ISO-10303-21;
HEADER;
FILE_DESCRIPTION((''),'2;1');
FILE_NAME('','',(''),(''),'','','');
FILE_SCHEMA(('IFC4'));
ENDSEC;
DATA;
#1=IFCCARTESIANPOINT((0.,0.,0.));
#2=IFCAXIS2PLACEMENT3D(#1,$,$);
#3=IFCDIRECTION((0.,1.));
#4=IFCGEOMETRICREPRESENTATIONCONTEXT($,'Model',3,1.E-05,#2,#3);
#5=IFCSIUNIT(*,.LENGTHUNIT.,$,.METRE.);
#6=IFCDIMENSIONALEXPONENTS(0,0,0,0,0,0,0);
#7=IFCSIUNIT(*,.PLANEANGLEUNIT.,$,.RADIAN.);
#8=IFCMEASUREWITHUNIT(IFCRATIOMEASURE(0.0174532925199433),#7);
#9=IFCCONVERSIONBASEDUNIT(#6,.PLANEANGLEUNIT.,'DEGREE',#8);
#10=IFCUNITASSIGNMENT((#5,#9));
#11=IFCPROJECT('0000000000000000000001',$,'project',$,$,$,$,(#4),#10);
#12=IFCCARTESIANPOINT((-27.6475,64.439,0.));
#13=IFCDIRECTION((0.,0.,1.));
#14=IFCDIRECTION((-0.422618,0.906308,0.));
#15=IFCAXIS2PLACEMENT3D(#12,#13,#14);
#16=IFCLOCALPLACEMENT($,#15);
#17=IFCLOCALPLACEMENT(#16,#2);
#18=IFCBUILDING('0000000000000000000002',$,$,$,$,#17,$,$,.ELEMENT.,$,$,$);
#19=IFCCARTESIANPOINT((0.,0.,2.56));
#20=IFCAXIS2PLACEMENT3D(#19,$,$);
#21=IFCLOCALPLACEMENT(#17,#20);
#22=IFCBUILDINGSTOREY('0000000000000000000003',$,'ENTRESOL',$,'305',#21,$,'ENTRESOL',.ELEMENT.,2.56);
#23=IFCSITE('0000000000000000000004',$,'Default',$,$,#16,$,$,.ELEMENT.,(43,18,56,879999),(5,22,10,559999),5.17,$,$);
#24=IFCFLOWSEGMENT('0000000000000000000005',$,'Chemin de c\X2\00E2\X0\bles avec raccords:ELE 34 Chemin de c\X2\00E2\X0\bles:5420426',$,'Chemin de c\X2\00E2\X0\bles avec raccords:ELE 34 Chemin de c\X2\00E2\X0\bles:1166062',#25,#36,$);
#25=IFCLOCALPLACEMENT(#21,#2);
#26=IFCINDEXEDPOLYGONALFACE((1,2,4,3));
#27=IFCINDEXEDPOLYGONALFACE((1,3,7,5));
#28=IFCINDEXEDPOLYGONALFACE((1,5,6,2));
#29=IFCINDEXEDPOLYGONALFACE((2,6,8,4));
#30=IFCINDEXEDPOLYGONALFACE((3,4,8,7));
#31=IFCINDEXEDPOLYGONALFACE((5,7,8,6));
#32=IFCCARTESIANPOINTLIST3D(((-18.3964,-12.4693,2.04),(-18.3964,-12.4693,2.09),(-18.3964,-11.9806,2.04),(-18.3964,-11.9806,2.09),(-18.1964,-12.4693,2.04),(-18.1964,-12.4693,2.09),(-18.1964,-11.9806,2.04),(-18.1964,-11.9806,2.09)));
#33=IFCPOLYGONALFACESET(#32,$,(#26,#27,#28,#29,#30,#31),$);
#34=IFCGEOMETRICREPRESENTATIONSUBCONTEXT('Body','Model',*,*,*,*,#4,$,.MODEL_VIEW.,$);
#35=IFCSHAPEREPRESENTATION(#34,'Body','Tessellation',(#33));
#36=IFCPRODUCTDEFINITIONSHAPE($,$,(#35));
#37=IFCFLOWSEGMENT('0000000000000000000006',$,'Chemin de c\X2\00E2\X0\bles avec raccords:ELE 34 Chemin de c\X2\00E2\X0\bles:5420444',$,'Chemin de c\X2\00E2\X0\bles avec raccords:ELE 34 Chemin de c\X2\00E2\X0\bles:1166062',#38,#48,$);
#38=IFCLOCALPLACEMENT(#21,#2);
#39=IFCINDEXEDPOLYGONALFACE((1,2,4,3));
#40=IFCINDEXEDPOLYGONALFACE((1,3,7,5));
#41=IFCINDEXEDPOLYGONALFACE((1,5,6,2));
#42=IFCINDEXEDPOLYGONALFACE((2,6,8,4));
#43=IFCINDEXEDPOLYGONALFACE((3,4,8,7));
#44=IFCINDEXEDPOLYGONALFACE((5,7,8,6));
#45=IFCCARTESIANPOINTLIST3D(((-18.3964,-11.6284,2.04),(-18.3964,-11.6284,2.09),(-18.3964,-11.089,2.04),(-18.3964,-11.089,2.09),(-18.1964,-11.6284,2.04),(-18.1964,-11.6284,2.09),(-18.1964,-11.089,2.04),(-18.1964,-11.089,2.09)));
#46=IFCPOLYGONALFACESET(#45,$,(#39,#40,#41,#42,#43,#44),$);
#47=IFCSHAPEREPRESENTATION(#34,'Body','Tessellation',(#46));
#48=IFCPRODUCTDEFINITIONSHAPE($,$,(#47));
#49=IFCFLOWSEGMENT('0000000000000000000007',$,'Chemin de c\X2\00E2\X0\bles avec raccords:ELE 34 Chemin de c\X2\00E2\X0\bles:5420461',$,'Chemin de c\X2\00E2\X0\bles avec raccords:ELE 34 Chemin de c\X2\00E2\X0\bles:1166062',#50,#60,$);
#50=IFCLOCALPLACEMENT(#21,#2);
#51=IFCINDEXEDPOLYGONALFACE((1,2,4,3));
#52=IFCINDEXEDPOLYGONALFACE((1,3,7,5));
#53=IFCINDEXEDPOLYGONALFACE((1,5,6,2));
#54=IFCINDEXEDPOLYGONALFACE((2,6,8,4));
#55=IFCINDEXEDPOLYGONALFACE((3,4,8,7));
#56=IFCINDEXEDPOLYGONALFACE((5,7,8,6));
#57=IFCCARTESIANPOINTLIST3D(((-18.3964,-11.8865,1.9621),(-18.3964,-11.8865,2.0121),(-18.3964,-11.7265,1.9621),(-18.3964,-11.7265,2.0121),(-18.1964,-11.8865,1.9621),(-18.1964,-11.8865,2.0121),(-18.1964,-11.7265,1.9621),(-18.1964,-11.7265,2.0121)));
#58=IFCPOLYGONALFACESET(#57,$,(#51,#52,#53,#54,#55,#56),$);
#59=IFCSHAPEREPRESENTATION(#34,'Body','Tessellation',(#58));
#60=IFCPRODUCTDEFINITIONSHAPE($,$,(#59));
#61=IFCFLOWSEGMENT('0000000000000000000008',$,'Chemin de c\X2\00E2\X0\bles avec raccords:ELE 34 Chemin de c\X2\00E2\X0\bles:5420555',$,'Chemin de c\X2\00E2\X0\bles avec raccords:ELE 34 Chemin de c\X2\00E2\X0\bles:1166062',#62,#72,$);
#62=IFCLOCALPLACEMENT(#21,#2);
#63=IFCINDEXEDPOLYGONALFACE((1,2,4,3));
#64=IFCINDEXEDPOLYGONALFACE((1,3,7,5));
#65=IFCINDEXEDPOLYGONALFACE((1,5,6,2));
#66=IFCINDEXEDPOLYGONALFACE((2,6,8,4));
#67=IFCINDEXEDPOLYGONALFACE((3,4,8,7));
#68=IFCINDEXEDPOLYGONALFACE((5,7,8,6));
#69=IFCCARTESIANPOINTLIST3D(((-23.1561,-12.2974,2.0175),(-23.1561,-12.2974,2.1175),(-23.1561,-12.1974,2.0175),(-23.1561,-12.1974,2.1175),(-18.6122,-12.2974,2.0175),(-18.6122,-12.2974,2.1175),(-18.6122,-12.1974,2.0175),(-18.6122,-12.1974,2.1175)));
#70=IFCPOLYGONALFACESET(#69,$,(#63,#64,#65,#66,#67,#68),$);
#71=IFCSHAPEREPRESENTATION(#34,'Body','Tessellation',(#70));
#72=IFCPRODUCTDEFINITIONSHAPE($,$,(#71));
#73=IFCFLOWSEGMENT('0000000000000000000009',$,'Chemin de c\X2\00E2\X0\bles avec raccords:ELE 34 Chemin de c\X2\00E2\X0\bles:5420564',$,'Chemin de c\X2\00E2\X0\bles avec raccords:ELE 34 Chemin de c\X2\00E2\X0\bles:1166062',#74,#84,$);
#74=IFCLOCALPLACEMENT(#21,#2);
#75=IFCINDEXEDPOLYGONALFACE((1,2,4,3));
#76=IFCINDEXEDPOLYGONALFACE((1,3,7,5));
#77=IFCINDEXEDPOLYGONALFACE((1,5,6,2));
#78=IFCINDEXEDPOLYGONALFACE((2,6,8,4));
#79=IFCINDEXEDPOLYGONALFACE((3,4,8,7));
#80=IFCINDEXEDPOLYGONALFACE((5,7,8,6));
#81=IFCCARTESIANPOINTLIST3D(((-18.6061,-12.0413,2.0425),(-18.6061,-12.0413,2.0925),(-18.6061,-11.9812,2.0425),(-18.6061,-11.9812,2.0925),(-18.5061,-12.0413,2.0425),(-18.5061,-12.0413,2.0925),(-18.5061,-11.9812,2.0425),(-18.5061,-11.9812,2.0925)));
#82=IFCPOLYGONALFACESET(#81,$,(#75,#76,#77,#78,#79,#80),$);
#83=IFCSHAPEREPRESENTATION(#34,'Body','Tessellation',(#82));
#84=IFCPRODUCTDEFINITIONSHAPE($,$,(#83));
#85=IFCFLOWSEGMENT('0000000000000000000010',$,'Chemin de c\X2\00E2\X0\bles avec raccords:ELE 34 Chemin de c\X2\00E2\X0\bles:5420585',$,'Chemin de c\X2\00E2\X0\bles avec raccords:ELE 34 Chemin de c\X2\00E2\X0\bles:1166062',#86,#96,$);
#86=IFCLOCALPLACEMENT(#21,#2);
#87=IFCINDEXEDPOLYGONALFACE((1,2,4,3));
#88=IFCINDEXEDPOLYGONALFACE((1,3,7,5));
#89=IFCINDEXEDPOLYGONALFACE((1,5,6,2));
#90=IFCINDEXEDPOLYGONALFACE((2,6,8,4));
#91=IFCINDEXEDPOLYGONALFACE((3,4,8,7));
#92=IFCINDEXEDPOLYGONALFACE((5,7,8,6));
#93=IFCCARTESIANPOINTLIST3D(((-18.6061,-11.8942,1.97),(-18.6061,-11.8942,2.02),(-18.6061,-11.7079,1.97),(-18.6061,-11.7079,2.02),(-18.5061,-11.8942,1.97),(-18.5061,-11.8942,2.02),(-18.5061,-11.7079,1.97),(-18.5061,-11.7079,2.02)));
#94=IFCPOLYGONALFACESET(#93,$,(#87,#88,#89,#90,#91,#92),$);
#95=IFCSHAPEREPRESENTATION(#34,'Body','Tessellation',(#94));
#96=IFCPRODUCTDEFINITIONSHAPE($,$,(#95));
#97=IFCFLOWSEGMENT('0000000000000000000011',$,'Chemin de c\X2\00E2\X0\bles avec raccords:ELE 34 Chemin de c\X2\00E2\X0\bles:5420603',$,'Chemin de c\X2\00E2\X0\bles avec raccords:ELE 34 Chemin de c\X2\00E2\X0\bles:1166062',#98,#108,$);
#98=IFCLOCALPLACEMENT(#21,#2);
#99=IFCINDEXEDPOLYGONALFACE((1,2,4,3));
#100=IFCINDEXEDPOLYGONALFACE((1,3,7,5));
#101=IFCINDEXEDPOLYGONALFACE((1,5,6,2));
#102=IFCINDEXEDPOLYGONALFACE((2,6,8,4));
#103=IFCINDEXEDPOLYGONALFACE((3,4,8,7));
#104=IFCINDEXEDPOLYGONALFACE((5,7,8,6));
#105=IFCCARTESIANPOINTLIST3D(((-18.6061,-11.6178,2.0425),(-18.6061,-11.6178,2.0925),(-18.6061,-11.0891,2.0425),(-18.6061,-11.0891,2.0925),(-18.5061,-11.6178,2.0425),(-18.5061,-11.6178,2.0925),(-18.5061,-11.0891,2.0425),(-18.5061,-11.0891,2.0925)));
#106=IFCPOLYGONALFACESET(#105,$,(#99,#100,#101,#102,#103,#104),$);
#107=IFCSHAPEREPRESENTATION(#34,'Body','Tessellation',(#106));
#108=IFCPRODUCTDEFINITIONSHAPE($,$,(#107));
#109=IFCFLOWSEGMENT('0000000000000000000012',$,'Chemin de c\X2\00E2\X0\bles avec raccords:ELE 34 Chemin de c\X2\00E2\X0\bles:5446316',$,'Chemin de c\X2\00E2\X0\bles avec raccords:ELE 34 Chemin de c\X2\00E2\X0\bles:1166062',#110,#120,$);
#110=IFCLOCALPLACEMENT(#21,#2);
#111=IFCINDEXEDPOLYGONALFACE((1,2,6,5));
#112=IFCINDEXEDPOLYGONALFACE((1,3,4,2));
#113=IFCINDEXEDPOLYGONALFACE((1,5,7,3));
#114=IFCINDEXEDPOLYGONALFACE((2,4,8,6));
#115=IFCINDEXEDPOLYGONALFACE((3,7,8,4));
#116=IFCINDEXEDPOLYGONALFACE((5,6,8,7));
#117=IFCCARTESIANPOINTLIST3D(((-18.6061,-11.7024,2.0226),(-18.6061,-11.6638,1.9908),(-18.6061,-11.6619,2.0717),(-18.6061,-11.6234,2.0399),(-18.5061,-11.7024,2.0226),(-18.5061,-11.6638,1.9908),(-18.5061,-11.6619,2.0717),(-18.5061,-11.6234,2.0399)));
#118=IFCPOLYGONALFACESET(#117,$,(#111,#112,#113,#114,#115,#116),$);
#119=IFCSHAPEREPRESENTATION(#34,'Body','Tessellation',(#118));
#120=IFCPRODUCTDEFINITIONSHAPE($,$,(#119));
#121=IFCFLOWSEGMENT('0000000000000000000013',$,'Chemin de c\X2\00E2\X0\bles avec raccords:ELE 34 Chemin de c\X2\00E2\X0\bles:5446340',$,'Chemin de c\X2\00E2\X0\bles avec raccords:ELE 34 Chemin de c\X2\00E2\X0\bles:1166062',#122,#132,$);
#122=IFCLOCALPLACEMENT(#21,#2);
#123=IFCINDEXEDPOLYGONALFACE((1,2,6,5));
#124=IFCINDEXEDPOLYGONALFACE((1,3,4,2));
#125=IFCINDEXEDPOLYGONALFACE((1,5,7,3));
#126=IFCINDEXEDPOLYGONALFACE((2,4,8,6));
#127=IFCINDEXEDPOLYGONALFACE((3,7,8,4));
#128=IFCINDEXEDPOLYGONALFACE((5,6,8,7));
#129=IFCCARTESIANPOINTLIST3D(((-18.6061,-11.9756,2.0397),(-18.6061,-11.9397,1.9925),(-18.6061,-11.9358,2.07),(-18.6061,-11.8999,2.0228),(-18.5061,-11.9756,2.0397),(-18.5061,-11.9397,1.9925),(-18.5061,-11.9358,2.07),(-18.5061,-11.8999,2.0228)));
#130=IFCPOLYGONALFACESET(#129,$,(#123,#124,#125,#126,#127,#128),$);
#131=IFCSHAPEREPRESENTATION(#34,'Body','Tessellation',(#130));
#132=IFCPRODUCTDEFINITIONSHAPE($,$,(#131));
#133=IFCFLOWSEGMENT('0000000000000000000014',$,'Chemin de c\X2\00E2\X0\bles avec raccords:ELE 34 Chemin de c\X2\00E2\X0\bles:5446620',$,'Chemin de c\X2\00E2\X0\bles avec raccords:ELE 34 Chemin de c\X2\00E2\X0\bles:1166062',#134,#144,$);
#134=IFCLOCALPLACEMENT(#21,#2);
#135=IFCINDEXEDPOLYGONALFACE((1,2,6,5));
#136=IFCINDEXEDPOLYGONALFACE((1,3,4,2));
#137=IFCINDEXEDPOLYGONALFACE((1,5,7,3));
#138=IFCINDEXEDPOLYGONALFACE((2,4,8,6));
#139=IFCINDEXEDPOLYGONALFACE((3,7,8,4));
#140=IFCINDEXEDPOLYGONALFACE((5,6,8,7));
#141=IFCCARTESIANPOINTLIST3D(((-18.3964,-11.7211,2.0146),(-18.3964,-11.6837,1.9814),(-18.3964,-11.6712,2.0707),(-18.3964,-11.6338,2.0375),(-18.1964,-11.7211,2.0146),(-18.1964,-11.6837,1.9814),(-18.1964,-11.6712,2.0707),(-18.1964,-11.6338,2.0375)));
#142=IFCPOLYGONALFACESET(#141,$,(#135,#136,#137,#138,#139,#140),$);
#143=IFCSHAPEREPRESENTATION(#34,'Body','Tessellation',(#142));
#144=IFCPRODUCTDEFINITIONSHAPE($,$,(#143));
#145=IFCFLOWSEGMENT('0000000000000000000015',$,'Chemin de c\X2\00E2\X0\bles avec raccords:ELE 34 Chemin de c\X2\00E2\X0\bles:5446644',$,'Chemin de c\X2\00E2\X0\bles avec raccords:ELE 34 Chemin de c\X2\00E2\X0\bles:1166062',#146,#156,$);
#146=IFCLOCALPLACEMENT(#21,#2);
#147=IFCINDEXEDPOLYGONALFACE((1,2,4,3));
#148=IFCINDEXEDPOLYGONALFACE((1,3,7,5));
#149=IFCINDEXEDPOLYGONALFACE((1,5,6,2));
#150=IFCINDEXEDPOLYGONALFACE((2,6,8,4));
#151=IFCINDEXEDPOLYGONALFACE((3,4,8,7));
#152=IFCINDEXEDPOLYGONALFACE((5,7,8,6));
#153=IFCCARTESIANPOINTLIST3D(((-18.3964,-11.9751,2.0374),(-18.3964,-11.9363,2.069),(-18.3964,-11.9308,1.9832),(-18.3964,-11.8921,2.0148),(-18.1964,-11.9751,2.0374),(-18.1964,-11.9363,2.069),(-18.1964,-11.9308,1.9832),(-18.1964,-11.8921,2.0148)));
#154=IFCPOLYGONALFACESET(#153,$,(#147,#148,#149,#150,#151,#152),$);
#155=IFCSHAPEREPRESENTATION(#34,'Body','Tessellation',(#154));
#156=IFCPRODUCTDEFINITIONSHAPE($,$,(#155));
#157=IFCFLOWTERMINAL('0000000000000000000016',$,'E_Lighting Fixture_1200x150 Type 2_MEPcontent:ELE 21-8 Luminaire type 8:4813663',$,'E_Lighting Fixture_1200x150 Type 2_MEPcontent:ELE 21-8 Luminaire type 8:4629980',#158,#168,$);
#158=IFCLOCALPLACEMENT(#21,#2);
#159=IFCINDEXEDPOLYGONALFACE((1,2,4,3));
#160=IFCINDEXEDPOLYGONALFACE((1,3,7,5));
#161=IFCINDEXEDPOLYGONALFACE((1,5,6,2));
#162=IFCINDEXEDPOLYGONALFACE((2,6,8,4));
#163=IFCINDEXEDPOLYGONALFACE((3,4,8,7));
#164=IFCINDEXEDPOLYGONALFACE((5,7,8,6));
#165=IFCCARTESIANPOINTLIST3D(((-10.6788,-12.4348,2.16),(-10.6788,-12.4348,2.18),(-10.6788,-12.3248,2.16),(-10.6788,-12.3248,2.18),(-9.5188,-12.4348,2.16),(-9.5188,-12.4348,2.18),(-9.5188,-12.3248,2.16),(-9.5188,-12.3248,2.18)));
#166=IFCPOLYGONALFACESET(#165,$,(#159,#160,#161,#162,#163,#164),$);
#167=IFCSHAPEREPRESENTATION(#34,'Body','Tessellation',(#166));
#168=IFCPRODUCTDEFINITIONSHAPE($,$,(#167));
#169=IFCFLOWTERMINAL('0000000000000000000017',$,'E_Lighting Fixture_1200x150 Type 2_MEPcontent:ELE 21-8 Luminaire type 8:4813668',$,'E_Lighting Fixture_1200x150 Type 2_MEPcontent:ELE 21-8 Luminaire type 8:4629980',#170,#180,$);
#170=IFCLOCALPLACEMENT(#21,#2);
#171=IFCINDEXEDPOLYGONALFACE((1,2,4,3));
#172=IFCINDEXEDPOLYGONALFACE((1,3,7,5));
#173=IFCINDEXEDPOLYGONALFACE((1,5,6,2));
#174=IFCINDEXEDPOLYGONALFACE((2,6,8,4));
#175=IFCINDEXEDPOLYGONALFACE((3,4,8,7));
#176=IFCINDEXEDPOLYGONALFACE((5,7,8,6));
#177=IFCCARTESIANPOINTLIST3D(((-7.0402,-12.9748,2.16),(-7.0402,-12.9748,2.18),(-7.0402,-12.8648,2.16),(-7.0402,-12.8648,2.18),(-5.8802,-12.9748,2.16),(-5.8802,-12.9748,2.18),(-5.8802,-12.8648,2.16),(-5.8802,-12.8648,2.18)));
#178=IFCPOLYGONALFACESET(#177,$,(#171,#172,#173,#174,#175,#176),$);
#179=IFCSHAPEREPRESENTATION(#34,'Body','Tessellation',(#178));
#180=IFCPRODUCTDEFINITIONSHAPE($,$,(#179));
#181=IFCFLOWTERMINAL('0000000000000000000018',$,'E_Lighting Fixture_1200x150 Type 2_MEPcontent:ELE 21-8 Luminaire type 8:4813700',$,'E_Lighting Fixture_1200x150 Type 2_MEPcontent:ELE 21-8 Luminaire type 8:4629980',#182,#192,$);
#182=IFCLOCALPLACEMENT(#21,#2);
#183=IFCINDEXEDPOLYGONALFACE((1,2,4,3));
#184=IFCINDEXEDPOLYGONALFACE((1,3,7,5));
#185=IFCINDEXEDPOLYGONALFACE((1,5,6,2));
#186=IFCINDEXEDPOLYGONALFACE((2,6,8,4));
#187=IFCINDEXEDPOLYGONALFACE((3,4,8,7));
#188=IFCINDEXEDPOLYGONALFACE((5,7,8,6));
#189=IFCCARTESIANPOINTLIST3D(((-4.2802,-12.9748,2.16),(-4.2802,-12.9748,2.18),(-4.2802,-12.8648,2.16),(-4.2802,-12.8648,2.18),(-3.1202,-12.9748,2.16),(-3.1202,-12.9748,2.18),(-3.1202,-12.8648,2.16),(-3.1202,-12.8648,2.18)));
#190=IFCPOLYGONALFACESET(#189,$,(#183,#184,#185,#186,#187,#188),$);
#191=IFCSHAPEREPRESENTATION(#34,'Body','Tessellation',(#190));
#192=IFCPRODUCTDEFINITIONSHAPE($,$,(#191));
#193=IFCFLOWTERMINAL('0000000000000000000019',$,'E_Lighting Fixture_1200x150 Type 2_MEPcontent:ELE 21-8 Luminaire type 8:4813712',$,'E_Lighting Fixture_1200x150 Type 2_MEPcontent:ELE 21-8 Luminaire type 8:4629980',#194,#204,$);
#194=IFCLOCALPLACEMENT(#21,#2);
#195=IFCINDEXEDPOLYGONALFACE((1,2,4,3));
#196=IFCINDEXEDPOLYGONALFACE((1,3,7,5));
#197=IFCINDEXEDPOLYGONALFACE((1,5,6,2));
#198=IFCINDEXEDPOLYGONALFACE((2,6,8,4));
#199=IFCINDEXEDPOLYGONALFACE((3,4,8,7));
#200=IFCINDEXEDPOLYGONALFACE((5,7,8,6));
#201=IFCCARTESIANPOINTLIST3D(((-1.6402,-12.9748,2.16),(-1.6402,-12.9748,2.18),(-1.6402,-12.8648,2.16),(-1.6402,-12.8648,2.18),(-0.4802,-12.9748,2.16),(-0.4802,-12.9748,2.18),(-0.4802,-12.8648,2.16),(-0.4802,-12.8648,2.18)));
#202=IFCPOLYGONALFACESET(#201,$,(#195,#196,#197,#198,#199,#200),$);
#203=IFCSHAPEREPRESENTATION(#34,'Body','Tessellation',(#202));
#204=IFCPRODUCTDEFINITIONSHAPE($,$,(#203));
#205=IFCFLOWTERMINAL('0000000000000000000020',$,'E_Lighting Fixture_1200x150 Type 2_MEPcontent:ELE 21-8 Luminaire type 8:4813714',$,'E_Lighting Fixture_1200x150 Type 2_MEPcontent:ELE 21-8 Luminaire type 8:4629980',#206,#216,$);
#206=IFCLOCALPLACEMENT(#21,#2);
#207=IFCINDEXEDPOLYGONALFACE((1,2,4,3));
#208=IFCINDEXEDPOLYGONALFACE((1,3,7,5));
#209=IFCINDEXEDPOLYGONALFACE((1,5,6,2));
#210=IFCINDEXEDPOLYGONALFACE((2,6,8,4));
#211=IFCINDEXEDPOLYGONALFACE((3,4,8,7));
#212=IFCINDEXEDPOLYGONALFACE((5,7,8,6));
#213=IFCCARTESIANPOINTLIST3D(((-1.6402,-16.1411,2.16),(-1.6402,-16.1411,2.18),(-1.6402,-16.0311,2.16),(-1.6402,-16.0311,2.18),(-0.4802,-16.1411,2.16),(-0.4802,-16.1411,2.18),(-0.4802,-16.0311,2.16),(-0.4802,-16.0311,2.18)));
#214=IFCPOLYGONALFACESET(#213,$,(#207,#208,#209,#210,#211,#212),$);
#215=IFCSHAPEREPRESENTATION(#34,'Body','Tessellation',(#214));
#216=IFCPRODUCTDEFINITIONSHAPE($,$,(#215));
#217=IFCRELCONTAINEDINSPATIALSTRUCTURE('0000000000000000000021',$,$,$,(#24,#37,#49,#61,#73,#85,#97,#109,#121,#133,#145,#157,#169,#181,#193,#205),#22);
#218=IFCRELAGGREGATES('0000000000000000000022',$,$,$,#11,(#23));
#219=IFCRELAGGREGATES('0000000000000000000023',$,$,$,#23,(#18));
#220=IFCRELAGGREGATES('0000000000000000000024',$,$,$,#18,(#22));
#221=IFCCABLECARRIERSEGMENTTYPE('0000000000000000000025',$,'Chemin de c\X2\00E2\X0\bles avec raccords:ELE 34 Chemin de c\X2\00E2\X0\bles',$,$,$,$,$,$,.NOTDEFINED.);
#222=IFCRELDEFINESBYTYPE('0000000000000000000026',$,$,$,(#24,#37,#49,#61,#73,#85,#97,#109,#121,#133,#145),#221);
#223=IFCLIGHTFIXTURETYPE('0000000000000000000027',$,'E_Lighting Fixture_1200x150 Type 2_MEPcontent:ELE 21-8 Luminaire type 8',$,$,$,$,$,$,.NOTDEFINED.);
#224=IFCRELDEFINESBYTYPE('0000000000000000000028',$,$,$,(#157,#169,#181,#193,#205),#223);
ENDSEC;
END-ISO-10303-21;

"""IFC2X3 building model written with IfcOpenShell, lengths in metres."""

from ifc_helpers import new_model, entity, si_unit, converted_unit, direction, frame, frame_2d, origin, origin_2d_with_axis, place, context, subcontext, project, spatial, rectangle, extrude, source, transform, mapped, type_object, type_shapes, element, save


model = new_model("IFC2X3")

# Units and contexts
model_context = context("Model", 3, precision=1e-05, world=origin(), true_north=direction((0.0, 1.0)))
body_context = subcontext(model_context, "Body", "Model", "MODEL_VIEW")
ifc_project = project(units=[si_unit("LENGTHUNIT", "METRE"), converted_unit("PLANEANGLEUNIT", "DEGREE", entity("IfcRatioMeasure", 0.0174532925199433), si_unit("PLANEANGLEUNIT", "RADIAN"), dimensions=[0, 0, 0, 0, 0, 0, 0])], contexts=[model_context])

# Site, building, storey
site_placement = place(None, frame((-27.6475, 64.439, 0.0), z_axis=(0.0, 0.0, 1.0), x_axis=(-0.422618, 0.906308, 0.0)))
site = spatial("IfcSite", under=ifc_project, at=site_placement, Name="Default", CompositionType="ELEMENT", RefLatitude=(43, 18, 56, 879999), RefLongitude=(5, 22, 10, 559999), RefElevation=5.17)
building_placement = place(site_placement, origin())
building = spatial("IfcBuilding", under=site, at=building_placement, CompositionType="ELEMENT")
storey_placement = place(building_placement, frame((0.0, 0.0, 2.56)))
storey = spatial("IfcBuildingStorey", under=building, at=storey_placement, Name="ENTRESOL", ObjectType="305", LongName="ENTRESOL", CompositionType="ELEMENT", Elevation=2.56)

# Flow segments
cable_carrier_segment_type = type_object("IfcCableCarrierSegmentType", Name="Chemin de câbles avec raccords:ELE 34 Chemin de câbles", PredefinedType="NOTDEFINED")
flow_segment_1_placement = place(storey_placement, origin())
element("IfcFlowSegment", 1, at=flow_segment_1_placement, inside=storey, type_object=cable_carrier_segment_type, Name="Chemin de câbles avec raccords:ELE 34 Chemin de câbles:5420426", ObjectType="Chemin de câbles avec raccords:ELE 34 Chemin de câbles:1166062", context=body_context, shape_type="SweptSolid", body=[
    extrude(rectangle(XDim=0.4886, YDim=0.2, at=frame_2d((0.0, 0.0), x_axis=(1.0, 0.0))), frame((-18.2964, -12.2249, 2.04), z_axis=(0.0, 0.000017, 1.0), x_axis=(0.0, 1.0, -0.000017)), (0.0, 0.0, 1.0), 0.05),
])
flow_segment_2_placement = place(storey_placement, origin())
element("IfcFlowSegment", 2, at=flow_segment_2_placement, inside=storey, type_object=cable_carrier_segment_type, Name="Chemin de câbles avec raccords:ELE 34 Chemin de câbles:5420444", ObjectType="Chemin de câbles avec raccords:ELE 34 Chemin de câbles:1166062", context=body_context, shape_type="SweptSolid", body=[
    extrude(rectangle(XDim=0.5394, YDim=0.2, at=frame_2d((0.0, 0.0), x_axis=(1.0, 0.0))), frame((-18.2964, -11.3587, 2.04), z_axis=(0.0, 0.0, 1.0), x_axis=(0.0, 1.0, 0.0)), (0.0, 0.0, 1.0), 0.05),
])
flow_segment_3_placement = place(storey_placement, origin())
element("IfcFlowSegment", 3, at=flow_segment_3_placement, inside=storey, type_object=cable_carrier_segment_type, Name="Chemin de câbles avec raccords:ELE 34 Chemin de câbles:5420461", ObjectType="Chemin de câbles avec raccords:ELE 34 Chemin de câbles:1166062", context=body_context, shape_type="SweptSolid", body=[
    extrude(rectangle(XDim=0.16, YDim=0.2, at=frame_2d((0.0, 0.0), x_axis=(1.0, 0.0))), frame((-18.2964, -11.8065, 1.9621), z_axis=(0.0, 0.0, 1.0), x_axis=(0.0, 1.0, 0.0)), (0.0, 0.0, 1.0), 0.05),
])
flow_segment_4_placement = place(storey_placement, origin())
element("IfcFlowSegment", 4, at=flow_segment_4_placement, inside=storey, type_object=cable_carrier_segment_type, Name="Chemin de câbles avec raccords:ELE 34 Chemin de câbles:5420555", ObjectType="Chemin de câbles avec raccords:ELE 34 Chemin de câbles:1166062", context=body_context, shape_type="SweptSolid", body=[
    extrude(rectangle(XDim=4.5439, YDim=0.1, at=frame_2d((0.0, 0.0), x_axis=(1.0, 0.0))), frame((-20.8842, -12.2474, 2.0175)), (0.0, 0.0, 1.0), 0.1),
])
flow_segment_5_placement = place(storey_placement, origin())
element("IfcFlowSegment", 5, at=flow_segment_5_placement, inside=storey, type_object=cable_carrier_segment_type, Name="Chemin de câbles avec raccords:ELE 34 Chemin de câbles:5420564", ObjectType="Chemin de câbles avec raccords:ELE 34 Chemin de câbles:1166062", context=body_context, shape_type="SweptSolid", body=[
    extrude(rectangle(XDim=0.0601, YDim=0.1, at=frame_2d((0.0, 0.0), x_axis=(1.0, 0.0))), frame((-18.5561, -12.0113, 2.0425), z_axis=(0.0, 0.0, 1.0), x_axis=(0.0, 1.0, 0.0)), (0.0, 0.0, 1.0), 0.05),
])
flow_segment_6_placement = place(storey_placement, origin())
element("IfcFlowSegment", 6, at=flow_segment_6_placement, inside=storey, type_object=cable_carrier_segment_type, Name="Chemin de câbles avec raccords:ELE 34 Chemin de câbles:5420585", ObjectType="Chemin de câbles avec raccords:ELE 34 Chemin de câbles:1166062", context=body_context, shape_type="SweptSolid", body=[
    extrude(rectangle(XDim=0.1863, YDim=0.1, at=origin_2d_with_axis()), frame((-18.5561, -11.8011, 1.97), z_axis=(0.0, 0.0, 1.0), x_axis=(0.0, 1.0, 0.0)), (0.0, 0.0, 1.0), 0.05),
])
flow_segment_7_placement = place(storey_placement, origin())
element("IfcFlowSegment", 7, at=flow_segment_7_placement, inside=storey, type_object=cable_carrier_segment_type, Name="Chemin de câbles avec raccords:ELE 34 Chemin de câbles:5420603", ObjectType="Chemin de câbles avec raccords:ELE 34 Chemin de câbles:1166062", context=body_context, shape_type="SweptSolid", body=[
    extrude(rectangle(XDim=0.5287, YDim=0.1, at=frame_2d((0.0, 0.0), x_axis=(1.0, 0.0))), frame((-18.5561, -11.3534, 2.0425), z_axis=(0.0, 0.0, 1.0), x_axis=(0.0, -1.0, 0.0)), (0.0, 0.0, 1.0), 0.05),
])
flow_segment_8_placement = place(storey_placement, origin())
element("IfcFlowSegment", 8, at=flow_segment_8_placement, inside=storey, type_object=cable_carrier_segment_type, Name="Chemin de câbles avec raccords:ELE 34 Chemin de câbles:5446316", ObjectType="Chemin de câbles avec raccords:ELE 34 Chemin de câbles:1166062", context=body_context, shape_type="SweptSolid", body=[
    extrude(rectangle(XDim=0.0636, YDim=0.05, at=frame_2d((0.0, 0.0), x_axis=(1.0, 0.0))), frame((-18.6061, -11.6629, 2.0312), z_axis=(1.0, 0.0, 0.0), x_axis=(0.0, 0.636095, 0.771611)), (0.0, 0.0, 1.0), 0.1),
])
flow_segment_9_placement = place(storey_placement, origin())
element("IfcFlowSegment", 9, at=flow_segment_9_placement, inside=storey, type_object=cable_carrier_segment_type, Name="Chemin de câbles avec raccords:ELE 34 Chemin de câbles:5446340", ObjectType="Chemin de câbles avec raccords:ELE 34 Chemin de câbles:1166062", context=body_context, shape_type="SweptSolid", body=[
    extrude(rectangle(XDim=0.0593, YDim=0.05, at=frame_2d((0.0, 0.0), x_axis=(1.0, 0.0))), frame((-18.6061, -11.9377, 2.0312), z_axis=(1.0, 0.0, 0.0), x_axis=(0.0, -0.605774, 0.795637)), (0.0, 0.0, 1.0), 0.1),
])
flow_segment_10_placement = place(storey_placement, origin())
element("IfcFlowSegment", 10, at=flow_segment_10_placement, inside=storey, type_object=cable_carrier_segment_type, Name="Chemin de câbles avec raccords:ELE 34 Chemin de câbles:5446620", ObjectType="Chemin de câbles avec raccords:ELE 34 Chemin de câbles:1166062", context=body_context, shape_type="SweptSolid", body=[
    extrude(rectangle(XDim=0.0751, YDim=0.05, at=frame_2d((0.0, 0.0), x_axis=(1.0, 0.0))), frame((-18.3964, -11.6775, 2.0261), z_axis=(1.0, 0.0, 0.0), x_axis=(0.0, 0.663724, 0.747978)), (0.0, 0.0, 1.0), 0.2),
])
flow_segment_11_placement = place(storey_placement, origin())
element("IfcFlowSegment", 11, at=flow_segment_11_placement, inside=storey, type_object=cable_carrier_segment_type, Name="Chemin de câbles avec raccords:ELE 34 Chemin de câbles:5446644", ObjectType="Chemin de câbles avec raccords:ELE 34 Chemin de câbles:1166062", context=body_context, shape_type="SweptSolid", body=[
    extrude(rectangle(XDim=0.0699, YDim=0.05, at=frame_2d((0.0, 0.0), x_axis=(1.0, 0.0))), frame((-18.3964, -11.9336, 2.0261), z_axis=(1.0, 0.0, 0.0), x_axis=(0.0, -0.632171, 0.774829)), (0.0, 0.0, 1.0), 0.2),
])

# Flow terminals
light_fixture_type_1 = type_object("IfcLightFixtureType", Name="E_Lighting Fixture_1200x150 Type 2_MEPcontent:ELE 21-8 Luminaire type 8", PredefinedType="NOTDEFINED")
shared_shape_1 = source(origin(), body_context, "Body", "SweptSolid", [
    extrude(rectangle(XDim=0.11, YDim=1.16, at=origin_2d_with_axis()), frame((0.0, 0.0, 0.0), z_axis=(0.0, 0.0, 1.0), x_axis=(0.0, -1.0, 0.0)), (0.0, 0.0, 1.0), 0.02),
])
type_shapes(light_fixture_type_1, [shared_shape_1])
for number, where, name in (
    (12, (-10.0988, -12.3798, 2.16), "E_Lighting Fixture_1200x150 Type 2_MEPcontent:ELE 21-8 Luminaire type 8:4813663"),
    (13, (-6.4602, -12.9198, 2.16), "E_Lighting Fixture_1200x150 Type 2_MEPcontent:ELE 21-8 Luminaire type 8:4813668"),
    (14, (-3.7002, -12.9198, 2.16), "E_Lighting Fixture_1200x150 Type 2_MEPcontent:ELE 21-8 Luminaire type 8:4813700"),
    (15, (-1.0602, -12.9198, 2.16), "E_Lighting Fixture_1200x150 Type 2_MEPcontent:ELE 21-8 Luminaire type 8:4813712"),
    (16, (-1.0602, -16.0861, 2.16), "E_Lighting Fixture_1200x150 Type 2_MEPcontent:ELE 21-8 Luminaire type 8:4813714"),
):
    element("IfcFlowTerminal", number, at=place(storey_placement, frame(where)), inside=storey, type_object=light_fixture_type_1, Name=name, ObjectType="E_Lighting Fixture_1200x150 Type 2_MEPcontent:ELE 21-8 Luminaire type 8:4629980", context=body_context, shape_type="MappedRepresentation", body=[
        mapped(shared_shape_1, transform((0.0, 0.0, 0.0), scale=1.0)),
    ])

save(model, "model.ifc")
